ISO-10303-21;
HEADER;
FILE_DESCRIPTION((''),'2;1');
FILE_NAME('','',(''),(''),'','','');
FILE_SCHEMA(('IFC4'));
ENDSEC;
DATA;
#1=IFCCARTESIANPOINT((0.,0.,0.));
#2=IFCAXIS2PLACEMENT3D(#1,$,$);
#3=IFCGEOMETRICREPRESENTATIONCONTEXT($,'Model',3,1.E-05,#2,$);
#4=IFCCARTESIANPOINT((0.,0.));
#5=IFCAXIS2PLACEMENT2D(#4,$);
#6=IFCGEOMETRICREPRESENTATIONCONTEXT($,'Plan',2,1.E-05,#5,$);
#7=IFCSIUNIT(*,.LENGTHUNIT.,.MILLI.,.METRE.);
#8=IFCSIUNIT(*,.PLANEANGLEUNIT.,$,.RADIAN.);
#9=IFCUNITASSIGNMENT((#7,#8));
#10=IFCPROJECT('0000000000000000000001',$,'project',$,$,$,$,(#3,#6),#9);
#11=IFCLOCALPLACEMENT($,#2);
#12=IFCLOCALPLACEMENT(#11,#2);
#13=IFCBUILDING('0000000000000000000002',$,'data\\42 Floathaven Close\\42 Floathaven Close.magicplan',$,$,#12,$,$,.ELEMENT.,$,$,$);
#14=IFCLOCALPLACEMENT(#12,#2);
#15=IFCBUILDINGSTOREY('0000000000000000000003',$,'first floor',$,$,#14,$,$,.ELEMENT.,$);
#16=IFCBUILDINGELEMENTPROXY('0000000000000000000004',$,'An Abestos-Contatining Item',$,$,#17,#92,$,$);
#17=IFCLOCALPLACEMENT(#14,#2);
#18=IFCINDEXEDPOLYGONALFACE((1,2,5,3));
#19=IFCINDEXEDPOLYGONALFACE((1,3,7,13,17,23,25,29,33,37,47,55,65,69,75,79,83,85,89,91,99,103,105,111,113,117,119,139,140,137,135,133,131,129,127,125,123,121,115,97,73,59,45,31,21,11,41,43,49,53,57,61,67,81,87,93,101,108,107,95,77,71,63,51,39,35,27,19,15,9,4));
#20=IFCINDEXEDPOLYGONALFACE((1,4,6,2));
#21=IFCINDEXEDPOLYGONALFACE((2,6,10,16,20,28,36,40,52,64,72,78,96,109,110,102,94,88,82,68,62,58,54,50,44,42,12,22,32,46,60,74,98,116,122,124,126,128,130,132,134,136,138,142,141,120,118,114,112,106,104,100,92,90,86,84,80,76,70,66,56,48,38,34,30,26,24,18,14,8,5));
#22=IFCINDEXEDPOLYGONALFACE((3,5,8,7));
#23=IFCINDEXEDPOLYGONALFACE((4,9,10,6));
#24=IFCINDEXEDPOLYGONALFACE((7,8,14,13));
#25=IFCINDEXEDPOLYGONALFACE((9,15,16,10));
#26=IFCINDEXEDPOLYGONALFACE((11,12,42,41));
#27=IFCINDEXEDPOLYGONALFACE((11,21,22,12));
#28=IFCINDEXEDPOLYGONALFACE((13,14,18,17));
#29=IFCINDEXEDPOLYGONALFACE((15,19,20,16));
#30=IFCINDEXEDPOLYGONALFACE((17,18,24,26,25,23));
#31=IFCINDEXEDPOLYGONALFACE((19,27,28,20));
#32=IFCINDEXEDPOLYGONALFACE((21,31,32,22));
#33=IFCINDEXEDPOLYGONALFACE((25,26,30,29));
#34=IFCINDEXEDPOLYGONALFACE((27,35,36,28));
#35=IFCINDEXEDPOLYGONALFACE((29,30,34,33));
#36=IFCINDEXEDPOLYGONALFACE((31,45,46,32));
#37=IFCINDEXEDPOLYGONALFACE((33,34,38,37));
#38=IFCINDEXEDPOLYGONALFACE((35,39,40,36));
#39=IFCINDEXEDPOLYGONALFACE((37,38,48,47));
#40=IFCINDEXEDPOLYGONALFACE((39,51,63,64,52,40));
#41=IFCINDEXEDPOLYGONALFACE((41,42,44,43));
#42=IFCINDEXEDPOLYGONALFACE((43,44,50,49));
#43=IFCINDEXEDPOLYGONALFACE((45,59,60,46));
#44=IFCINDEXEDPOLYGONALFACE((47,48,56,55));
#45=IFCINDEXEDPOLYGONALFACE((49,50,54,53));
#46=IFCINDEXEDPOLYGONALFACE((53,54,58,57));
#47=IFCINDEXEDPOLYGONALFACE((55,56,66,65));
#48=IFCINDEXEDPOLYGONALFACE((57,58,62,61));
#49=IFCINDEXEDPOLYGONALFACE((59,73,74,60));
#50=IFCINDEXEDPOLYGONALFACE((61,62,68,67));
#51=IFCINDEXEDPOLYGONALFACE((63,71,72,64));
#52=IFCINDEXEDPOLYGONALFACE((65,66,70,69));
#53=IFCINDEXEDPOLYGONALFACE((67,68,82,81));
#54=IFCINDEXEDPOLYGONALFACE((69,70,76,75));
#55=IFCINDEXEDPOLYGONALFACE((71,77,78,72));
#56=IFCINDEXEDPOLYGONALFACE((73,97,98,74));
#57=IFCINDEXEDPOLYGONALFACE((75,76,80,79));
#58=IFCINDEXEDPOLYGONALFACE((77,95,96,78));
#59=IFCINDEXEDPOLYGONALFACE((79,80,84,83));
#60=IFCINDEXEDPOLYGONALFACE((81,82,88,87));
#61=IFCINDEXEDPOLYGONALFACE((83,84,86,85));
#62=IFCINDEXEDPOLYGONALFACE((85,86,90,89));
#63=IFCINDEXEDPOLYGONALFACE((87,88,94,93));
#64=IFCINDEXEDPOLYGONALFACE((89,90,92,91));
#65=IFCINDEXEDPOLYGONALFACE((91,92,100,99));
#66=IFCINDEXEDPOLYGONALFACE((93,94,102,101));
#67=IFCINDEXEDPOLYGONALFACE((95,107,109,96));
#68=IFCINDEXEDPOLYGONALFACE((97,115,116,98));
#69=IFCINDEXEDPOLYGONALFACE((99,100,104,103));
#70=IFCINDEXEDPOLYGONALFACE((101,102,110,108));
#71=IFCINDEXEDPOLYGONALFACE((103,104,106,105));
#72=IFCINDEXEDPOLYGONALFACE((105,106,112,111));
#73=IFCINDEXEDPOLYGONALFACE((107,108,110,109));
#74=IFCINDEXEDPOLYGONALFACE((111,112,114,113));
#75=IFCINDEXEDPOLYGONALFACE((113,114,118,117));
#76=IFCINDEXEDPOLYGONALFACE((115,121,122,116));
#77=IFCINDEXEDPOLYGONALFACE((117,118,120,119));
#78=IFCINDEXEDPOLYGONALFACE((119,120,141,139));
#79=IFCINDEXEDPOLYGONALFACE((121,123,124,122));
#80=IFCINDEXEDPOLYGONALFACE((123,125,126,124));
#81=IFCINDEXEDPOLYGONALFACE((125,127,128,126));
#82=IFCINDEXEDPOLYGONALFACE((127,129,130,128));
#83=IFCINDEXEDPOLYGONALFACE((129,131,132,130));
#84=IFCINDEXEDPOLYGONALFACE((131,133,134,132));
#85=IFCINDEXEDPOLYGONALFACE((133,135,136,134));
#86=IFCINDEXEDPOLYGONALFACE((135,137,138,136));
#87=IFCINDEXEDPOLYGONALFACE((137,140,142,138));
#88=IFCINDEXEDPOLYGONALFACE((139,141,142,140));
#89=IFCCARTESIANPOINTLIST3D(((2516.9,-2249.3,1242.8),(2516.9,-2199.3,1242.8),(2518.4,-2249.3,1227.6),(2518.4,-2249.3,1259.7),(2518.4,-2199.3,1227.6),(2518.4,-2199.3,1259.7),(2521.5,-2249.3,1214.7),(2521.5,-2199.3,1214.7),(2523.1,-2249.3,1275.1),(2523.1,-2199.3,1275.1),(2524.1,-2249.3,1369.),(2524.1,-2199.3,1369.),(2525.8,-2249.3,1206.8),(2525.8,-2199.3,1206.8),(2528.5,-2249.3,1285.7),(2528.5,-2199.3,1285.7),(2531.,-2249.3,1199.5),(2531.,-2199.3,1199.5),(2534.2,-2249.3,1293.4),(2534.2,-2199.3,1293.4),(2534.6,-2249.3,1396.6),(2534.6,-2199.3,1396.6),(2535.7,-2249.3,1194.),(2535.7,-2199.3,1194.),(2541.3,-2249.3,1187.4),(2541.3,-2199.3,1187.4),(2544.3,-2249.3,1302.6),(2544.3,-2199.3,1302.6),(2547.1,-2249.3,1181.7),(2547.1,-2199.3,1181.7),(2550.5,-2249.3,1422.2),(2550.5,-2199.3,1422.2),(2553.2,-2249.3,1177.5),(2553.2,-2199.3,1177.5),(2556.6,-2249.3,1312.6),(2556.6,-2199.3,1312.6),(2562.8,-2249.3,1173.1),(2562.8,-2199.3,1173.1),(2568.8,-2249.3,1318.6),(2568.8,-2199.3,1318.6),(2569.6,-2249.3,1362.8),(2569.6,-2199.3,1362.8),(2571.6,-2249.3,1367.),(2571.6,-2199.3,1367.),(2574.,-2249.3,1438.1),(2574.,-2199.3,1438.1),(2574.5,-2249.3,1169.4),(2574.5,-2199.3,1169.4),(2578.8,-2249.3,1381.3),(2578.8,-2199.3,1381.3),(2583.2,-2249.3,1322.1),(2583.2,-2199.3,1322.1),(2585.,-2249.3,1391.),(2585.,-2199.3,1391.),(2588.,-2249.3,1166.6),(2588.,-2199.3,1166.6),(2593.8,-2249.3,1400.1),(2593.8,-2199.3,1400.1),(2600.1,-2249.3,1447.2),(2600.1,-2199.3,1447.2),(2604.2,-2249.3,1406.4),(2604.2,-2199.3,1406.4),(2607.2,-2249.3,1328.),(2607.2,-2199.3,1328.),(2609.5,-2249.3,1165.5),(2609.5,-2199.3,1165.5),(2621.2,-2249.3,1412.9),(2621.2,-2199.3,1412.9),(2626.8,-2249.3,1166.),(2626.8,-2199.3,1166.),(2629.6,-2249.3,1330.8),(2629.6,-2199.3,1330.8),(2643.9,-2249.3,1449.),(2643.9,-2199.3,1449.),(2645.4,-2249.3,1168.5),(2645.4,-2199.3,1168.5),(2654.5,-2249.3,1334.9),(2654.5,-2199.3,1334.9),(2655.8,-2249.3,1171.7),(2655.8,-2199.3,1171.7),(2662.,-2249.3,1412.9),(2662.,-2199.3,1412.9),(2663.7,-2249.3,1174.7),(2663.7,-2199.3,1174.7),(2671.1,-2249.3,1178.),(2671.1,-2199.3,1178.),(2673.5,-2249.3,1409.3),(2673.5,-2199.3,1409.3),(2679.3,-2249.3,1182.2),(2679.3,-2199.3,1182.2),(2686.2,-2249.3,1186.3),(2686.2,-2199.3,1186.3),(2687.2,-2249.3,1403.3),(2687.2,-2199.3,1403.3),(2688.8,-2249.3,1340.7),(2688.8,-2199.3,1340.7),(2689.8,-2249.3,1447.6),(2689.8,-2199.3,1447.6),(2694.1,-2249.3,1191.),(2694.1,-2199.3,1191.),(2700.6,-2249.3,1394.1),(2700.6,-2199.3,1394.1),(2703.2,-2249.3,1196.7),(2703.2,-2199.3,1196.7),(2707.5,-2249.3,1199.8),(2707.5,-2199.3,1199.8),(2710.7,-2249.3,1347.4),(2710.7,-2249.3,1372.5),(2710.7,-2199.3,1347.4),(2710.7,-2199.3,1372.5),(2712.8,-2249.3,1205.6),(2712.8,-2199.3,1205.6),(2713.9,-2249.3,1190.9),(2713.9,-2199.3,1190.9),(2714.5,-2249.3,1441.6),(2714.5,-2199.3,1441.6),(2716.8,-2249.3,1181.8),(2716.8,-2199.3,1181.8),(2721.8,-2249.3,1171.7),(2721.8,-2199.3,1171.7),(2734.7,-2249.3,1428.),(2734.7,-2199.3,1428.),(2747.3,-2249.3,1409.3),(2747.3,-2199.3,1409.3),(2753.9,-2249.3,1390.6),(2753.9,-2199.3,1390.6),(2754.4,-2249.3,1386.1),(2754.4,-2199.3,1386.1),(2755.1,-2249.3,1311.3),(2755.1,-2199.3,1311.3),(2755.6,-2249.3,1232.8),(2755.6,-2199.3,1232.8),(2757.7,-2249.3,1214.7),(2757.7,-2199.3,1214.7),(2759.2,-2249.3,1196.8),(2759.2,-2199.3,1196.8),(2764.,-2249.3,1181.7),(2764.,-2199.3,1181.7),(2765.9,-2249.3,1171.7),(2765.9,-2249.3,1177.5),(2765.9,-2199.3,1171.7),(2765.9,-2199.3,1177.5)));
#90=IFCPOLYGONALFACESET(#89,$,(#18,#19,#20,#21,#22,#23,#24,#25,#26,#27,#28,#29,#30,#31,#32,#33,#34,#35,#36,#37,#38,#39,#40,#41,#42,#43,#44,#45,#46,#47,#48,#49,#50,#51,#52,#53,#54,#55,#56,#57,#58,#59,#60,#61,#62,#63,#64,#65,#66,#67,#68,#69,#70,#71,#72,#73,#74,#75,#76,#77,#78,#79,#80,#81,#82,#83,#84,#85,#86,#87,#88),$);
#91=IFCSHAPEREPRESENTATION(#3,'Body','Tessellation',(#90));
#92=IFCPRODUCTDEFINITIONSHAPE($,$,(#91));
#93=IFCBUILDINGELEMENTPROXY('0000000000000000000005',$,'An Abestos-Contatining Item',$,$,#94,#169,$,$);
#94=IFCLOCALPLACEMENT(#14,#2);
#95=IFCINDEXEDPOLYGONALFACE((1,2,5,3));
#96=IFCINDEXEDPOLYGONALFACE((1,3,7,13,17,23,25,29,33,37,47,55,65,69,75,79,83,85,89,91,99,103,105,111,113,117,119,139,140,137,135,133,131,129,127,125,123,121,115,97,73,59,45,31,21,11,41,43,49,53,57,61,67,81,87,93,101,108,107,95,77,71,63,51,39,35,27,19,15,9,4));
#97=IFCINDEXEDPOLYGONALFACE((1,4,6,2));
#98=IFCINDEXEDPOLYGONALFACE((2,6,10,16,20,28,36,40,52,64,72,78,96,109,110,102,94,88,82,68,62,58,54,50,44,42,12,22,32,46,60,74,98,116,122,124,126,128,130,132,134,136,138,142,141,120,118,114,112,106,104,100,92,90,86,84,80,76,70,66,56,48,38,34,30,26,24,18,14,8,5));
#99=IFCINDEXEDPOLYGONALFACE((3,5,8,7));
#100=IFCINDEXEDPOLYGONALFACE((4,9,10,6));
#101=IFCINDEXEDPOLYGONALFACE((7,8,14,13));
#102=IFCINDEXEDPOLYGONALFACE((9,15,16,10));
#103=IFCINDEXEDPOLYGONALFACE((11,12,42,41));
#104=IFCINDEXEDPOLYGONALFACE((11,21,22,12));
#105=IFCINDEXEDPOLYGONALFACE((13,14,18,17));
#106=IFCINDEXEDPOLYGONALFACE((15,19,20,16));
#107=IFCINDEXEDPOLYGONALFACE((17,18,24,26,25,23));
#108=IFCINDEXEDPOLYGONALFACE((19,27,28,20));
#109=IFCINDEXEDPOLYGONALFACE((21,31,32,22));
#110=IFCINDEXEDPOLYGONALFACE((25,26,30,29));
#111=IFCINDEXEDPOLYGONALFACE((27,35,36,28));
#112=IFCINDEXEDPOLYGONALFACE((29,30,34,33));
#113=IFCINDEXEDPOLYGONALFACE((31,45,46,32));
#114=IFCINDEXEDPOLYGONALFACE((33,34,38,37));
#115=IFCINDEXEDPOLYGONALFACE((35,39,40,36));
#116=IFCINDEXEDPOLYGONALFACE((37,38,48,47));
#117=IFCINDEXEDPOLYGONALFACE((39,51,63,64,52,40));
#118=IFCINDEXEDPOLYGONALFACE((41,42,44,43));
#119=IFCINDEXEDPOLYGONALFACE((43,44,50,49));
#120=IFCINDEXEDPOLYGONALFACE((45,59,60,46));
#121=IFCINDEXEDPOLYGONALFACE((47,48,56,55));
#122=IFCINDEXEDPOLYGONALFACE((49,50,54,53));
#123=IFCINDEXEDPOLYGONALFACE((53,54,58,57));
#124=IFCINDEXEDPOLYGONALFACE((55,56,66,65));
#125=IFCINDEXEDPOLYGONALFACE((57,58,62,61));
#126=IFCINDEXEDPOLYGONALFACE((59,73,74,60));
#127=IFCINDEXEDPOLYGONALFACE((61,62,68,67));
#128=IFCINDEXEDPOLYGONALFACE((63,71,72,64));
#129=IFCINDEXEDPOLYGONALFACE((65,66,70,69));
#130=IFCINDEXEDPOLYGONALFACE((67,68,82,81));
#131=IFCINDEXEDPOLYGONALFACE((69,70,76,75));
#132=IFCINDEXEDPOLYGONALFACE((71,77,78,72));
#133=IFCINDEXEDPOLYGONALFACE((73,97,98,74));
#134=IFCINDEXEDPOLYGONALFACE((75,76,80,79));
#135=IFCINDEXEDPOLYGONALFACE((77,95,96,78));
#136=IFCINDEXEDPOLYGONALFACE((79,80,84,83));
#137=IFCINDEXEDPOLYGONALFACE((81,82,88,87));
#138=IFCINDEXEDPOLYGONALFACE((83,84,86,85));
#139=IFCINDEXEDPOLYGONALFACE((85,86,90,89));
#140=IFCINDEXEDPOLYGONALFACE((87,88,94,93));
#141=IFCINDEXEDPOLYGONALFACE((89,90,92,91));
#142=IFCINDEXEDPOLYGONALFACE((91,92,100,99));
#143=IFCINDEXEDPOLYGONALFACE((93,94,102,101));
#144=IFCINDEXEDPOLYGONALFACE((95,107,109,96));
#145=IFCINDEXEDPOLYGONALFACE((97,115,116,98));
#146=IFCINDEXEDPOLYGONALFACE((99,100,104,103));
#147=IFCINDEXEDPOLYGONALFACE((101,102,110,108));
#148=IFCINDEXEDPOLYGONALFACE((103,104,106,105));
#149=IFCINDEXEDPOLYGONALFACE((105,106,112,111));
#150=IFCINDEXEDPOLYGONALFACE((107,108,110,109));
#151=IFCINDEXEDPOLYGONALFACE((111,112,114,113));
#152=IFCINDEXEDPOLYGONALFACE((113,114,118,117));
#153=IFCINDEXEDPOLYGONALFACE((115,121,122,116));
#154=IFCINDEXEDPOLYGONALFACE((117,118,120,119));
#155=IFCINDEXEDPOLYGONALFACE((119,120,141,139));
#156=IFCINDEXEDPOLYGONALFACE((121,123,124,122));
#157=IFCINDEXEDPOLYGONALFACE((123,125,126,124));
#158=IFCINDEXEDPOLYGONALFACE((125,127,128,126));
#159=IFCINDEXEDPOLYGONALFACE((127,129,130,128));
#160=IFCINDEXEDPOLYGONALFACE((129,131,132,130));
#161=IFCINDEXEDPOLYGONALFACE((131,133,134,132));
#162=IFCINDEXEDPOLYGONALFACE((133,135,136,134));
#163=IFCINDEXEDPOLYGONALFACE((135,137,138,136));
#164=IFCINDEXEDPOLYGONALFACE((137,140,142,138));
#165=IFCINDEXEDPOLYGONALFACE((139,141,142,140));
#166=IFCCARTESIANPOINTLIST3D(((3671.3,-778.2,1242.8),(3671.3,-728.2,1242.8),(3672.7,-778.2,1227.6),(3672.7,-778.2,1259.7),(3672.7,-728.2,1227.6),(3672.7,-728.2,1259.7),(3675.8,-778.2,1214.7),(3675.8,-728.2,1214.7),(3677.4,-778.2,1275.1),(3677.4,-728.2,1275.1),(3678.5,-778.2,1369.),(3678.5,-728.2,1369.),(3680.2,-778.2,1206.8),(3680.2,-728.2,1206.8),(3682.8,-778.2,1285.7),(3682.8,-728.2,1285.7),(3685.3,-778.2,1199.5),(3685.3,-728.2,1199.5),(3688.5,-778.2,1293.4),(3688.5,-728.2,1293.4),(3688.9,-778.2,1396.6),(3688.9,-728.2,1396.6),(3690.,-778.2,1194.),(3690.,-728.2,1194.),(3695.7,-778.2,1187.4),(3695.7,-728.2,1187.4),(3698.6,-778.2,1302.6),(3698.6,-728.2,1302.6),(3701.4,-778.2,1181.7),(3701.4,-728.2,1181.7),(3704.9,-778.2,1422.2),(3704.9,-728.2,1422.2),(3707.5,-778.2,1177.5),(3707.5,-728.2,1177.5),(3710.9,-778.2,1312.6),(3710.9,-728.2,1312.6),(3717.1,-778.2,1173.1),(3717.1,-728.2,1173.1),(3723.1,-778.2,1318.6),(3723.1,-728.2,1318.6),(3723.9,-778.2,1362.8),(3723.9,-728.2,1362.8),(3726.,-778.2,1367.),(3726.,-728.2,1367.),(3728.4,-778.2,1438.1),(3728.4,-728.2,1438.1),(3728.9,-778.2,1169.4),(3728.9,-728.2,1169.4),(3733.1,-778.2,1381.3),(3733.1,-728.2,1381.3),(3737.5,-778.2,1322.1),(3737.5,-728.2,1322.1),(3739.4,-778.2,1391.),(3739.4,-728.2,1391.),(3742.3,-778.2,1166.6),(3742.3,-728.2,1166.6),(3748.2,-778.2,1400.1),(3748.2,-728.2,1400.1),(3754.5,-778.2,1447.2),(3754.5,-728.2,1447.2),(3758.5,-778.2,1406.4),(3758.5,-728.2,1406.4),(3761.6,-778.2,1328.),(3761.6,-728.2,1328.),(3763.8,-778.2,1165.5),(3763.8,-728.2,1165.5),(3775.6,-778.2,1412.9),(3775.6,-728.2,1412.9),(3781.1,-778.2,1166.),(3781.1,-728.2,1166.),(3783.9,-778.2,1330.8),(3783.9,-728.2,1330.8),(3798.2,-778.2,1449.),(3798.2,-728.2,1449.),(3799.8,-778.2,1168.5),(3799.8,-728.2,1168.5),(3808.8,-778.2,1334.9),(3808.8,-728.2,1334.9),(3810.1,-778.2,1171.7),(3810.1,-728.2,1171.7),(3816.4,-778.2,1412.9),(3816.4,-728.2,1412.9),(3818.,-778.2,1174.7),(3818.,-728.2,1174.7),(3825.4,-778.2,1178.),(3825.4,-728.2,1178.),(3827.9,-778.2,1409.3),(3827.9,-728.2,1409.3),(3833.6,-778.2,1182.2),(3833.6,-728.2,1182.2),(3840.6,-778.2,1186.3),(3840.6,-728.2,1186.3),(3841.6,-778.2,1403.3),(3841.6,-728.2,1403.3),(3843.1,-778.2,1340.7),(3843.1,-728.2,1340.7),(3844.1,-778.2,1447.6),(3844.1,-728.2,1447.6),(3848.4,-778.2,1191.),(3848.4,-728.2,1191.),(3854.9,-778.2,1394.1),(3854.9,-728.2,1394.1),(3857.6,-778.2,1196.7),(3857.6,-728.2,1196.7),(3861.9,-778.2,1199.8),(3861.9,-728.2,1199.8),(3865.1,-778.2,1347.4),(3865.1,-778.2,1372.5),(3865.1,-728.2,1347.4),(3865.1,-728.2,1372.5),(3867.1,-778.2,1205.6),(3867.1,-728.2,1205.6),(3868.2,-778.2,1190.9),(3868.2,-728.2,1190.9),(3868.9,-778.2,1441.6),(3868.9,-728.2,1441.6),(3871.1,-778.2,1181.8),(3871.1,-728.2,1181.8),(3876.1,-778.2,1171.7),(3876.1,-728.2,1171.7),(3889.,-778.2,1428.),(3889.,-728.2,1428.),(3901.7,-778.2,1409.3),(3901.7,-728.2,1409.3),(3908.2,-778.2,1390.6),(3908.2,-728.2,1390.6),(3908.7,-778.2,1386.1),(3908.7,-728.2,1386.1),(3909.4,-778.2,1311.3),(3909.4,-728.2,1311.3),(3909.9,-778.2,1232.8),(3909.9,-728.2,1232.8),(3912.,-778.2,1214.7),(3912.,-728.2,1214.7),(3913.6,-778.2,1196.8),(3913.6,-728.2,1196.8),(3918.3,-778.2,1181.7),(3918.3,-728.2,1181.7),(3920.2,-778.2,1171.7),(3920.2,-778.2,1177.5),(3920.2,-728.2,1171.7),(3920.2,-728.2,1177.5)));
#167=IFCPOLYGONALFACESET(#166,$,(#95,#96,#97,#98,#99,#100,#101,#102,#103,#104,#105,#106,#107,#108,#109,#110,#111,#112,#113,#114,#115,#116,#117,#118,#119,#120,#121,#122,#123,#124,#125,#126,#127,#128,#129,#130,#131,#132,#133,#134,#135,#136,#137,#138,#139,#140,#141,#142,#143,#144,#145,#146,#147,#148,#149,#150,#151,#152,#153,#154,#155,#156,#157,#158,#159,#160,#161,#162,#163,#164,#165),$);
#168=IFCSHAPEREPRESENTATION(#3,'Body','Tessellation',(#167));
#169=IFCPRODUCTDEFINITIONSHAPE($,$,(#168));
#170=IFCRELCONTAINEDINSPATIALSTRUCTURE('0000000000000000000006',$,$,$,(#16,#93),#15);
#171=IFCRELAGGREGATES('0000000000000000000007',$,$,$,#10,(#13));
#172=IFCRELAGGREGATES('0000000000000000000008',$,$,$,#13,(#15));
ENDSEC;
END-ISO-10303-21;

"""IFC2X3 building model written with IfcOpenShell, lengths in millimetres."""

from ifc_helpers import new_model, si_unit, frame, origin, origin_2d, place, context, project, spatial, polyline, outline, extrude, element, save


model = new_model("IFC2X3")

# Units and contexts
model_context = context("Model", 3, precision=1e-05, world=origin())
plan_context = context("Plan", 2, precision=1e-05, world=origin_2d())
ifc_project = project(units=[si_unit("LENGTHUNIT", "METRE", prefix="MILLI"), si_unit("PLANEANGLEUNIT", "RADIAN")], contexts=[model_context, plan_context])

# Building, storey
placement_1 = place(None, origin())
building_placement = place(placement_1, origin())
building = spatial("IfcBuilding", under=ifc_project, at=building_placement, Name="data\\42 Floathaven Close\\42 Floathaven Close.magicplan", CompositionType="ELEMENT")
storey_placement = place(building_placement, origin())
storey = spatial("IfcBuildingStorey", under=building, at=storey_placement, Name="first floor", CompositionType="ELEMENT")

# Building element proxies
placement_2 = place(None, frame((3168.1, -1388.8, 0.0)))
proxy_1_placement = place(placement_2, frame((-652.2, -810.5, 1165.0)))
element("IfcBuildingElementProxy", 1, at=proxy_1_placement, inside=storey, Name="An Abestos-Contatining Item", context=model_context, shape_type="SurfaceModel", body=[
    extrude(outline(polyline([(239.2, 0.0, 146.3), (239.7, 0.0, 67.8), (241.8, 0.0, 49.7), (243.3, 0.0, 31.9), (248.1, 0.0, 16.7), (250.0, 0.0, 12.5), (250.0, 0.0, 6.7), (205.8, 0.0, 6.7), (200.9, 0.0, 16.8), (197.9, 0.0, 25.9), (196.9, 0.0, 40.6), (191.6, 0.0, 34.8), (187.3, 0.0, 31.7), (178.2, 0.0, 26.0), (170.3, 0.0, 21.3), (163.4, 0.0, 17.2), (155.2, 0.0, 13.0), (147.8, 0.0, 9.7), (139.9, 0.0, 6.7), (129.5, 0.0, 3.5), (110.9, 0.0, 1.0), (93.6, 0.0, 0.5), (72.1, 0.0, 1.6), (58.6, 0.0, 4.4), (46.9, 0.0, 8.1), (37.3, 0.0, 12.5), (31.2, 0.0, 16.7), (25.4, 0.0, 22.4), (19.8, 0.0, 29.0), (15.1, 0.0, 34.5), (9.9, 0.0, 41.9), (5.5, 0.0, 49.7), (2.5, 0.0, 62.6), (1.0, 0.0, 77.8), (2.5, 0.0, 94.7), (7.2, 0.0, 110.1), (12.6, 0.0, 120.7), (18.2, 0.0, 128.4), (28.4, 0.0, 137.6), (40.7, 0.0, 147.6), (52.9, 0.0, 153.6), (67.3, 0.0, 157.1), (91.3, 0.0, 163.0), (113.7, 0.0, 165.8), (138.6, 0.0, 169.9), (172.9, 0.0, 175.7), (194.8, 0.0, 182.4), (194.8, 0.0, 207.5), (184.7, 0.0, 229.1), (171.3, 0.0, 238.3), (157.6, 0.0, 244.3), (146.2, 0.0, 247.9), (105.3, 0.0, 247.9), (88.3, 0.0, 241.4), (77.9, 0.0, 235.1), (69.1, 0.0, 226.0), (62.9, 0.0, 216.3), (55.7, 0.0, 202.0), (53.6, 0.0, 197.8), (8.2, 0.0, 204.0), (18.7, 0.0, 231.7), (34.6, 0.0, 257.2), (58.1, 0.0, 273.1), (84.2, 0.0, 282.2), (128.0, 0.0, 284.0), (173.9, 0.0, 282.6), (198.6, 0.0, 276.6), (218.8, 0.0, 263.1), (231.4, 0.0, 244.3), (238.0, 0.0, 225.6), (238.5, 0.0, 221.1)]), holes=[polyline([(193.0, 0.0, 144.2), (193.0, 0.0, 117.7), (190.5, 0.0, 97.8), (183.8, 0.0, 80.4), (174.2, 0.0, 64.5), (165.3, 0.0, 54.4), (152.5, 0.0, 47.3), (138.0, 0.0, 41.5), (124.6, 0.0, 37.8), (85.5, 0.0, 37.8), (75.0, 0.0, 41.4), (65.8, 0.0, 47.1), (57.8, 0.0, 55.4), (52.1, 0.0, 66.4), (49.5, 0.0, 74.4), (49.5, 0.0, 88.6), (55.3, 0.0, 100.7), (65.3, 0.0, 109.9), (81.0, 0.0, 119.8), (101.0, 0.0, 125.3), (119.9, 0.0, 128.5), (146.8, 0.0, 131.5), (165.0, 0.0, 134.9), (179.8, 0.0, 140.1), (193.0, 0.0, 144.2)])], kind="CURVE"), origin(), (0.0, -1.0, 0.0), 50.0),
])
placement_3 = place(None, frame((3168.1, -1388.8, 0.0)))
proxy_2_placement = place(placement_3, frame((502.2, 660.5, 1165.0)))
element("IfcBuildingElementProxy", 2, at=proxy_2_placement, inside=storey, Name="An Abestos-Contatining Item", context=model_context, shape_type="SurfaceModel", body=[
    extrude(outline(polyline([(239.2, 0.0, 146.3), (239.7, 0.0, 67.8), (241.8, 0.0, 49.7), (243.3, 0.0, 31.9), (248.1, 0.0, 16.7), (250.0, 0.0, 12.5), (250.0, 0.0, 6.7), (205.8, 0.0, 6.7), (200.9, 0.0, 16.8), (197.9, 0.0, 25.9), (196.9, 0.0, 40.6), (191.6, 0.0, 34.8), (187.3, 0.0, 31.7), (178.2, 0.0, 26.0), (170.3, 0.0, 21.3), (163.4, 0.0, 17.2), (155.2, 0.0, 13.0), (147.8, 0.0, 9.7), (139.9, 0.0, 6.7), (129.5, 0.0, 3.5), (110.9, 0.0, 1.0), (93.6, 0.0, 0.5), (72.1, 0.0, 1.6), (58.6, 0.0, 4.4), (46.9, 0.0, 8.1), (37.3, 0.0, 12.5), (31.2, 0.0, 16.7), (25.4, 0.0, 22.4), (19.8, 0.0, 29.0), (15.1, 0.0, 34.5), (9.9, 0.0, 41.9), (5.5, 0.0, 49.7), (2.5, 0.0, 62.6), (1.0, 0.0, 77.8), (2.5, 0.0, 94.7), (7.2, 0.0, 110.1), (12.6, 0.0, 120.7), (18.2, 0.0, 128.4), (28.4, 0.0, 137.6), (40.7, 0.0, 147.6), (52.9, 0.0, 153.6), (67.3, 0.0, 157.1), (91.3, 0.0, 163.0), (113.7, 0.0, 165.8), (138.6, 0.0, 169.9), (172.9, 0.0, 175.7), (194.8, 0.0, 182.4), (194.8, 0.0, 207.5), (184.7, 0.0, 229.1), (171.3, 0.0, 238.3), (157.6, 0.0, 244.3), (146.2, 0.0, 247.9), (105.3, 0.0, 247.9), (88.3, 0.0, 241.4), (77.9, 0.0, 235.1), (69.1, 0.0, 226.0), (62.9, 0.0, 216.3), (55.7, 0.0, 202.0), (53.6, 0.0, 197.8), (8.2, 0.0, 204.0), (18.7, 0.0, 231.7), (34.6, 0.0, 257.2), (58.1, 0.0, 273.1), (84.2, 0.0, 282.2), (128.0, 0.0, 284.0), (173.9, 0.0, 282.6), (198.6, 0.0, 276.6), (218.8, 0.0, 263.1), (231.4, 0.0, 244.3), (238.0, 0.0, 225.6), (238.5, 0.0, 221.1)]), holes=[polyline([(193.0, 0.0, 144.2), (193.0, 0.0, 117.7), (190.5, 0.0, 97.8), (183.8, 0.0, 80.4), (174.2, 0.0, 64.5), (165.3, 0.0, 54.4), (152.5, 0.0, 47.3), (138.0, 0.0, 41.5), (124.6, 0.0, 37.8), (85.5, 0.0, 37.8), (75.0, 0.0, 41.4), (65.8, 0.0, 47.1), (57.8, 0.0, 55.4), (52.1, 0.0, 66.4), (49.5, 0.0, 74.4), (49.5, 0.0, 88.6), (55.3, 0.0, 100.7), (65.3, 0.0, 109.9), (81.0, 0.0, 119.8), (101.0, 0.0, 125.3), (119.9, 0.0, 128.5), (146.8, 0.0, 131.5), (165.0, 0.0, 134.9), (179.8, 0.0, 140.1), (193.0, 0.0, 144.2)])], kind="CURVE"), origin(), (0.0, -1.0, 0.0), 50.0),
])

save(model, "model.ifc")
